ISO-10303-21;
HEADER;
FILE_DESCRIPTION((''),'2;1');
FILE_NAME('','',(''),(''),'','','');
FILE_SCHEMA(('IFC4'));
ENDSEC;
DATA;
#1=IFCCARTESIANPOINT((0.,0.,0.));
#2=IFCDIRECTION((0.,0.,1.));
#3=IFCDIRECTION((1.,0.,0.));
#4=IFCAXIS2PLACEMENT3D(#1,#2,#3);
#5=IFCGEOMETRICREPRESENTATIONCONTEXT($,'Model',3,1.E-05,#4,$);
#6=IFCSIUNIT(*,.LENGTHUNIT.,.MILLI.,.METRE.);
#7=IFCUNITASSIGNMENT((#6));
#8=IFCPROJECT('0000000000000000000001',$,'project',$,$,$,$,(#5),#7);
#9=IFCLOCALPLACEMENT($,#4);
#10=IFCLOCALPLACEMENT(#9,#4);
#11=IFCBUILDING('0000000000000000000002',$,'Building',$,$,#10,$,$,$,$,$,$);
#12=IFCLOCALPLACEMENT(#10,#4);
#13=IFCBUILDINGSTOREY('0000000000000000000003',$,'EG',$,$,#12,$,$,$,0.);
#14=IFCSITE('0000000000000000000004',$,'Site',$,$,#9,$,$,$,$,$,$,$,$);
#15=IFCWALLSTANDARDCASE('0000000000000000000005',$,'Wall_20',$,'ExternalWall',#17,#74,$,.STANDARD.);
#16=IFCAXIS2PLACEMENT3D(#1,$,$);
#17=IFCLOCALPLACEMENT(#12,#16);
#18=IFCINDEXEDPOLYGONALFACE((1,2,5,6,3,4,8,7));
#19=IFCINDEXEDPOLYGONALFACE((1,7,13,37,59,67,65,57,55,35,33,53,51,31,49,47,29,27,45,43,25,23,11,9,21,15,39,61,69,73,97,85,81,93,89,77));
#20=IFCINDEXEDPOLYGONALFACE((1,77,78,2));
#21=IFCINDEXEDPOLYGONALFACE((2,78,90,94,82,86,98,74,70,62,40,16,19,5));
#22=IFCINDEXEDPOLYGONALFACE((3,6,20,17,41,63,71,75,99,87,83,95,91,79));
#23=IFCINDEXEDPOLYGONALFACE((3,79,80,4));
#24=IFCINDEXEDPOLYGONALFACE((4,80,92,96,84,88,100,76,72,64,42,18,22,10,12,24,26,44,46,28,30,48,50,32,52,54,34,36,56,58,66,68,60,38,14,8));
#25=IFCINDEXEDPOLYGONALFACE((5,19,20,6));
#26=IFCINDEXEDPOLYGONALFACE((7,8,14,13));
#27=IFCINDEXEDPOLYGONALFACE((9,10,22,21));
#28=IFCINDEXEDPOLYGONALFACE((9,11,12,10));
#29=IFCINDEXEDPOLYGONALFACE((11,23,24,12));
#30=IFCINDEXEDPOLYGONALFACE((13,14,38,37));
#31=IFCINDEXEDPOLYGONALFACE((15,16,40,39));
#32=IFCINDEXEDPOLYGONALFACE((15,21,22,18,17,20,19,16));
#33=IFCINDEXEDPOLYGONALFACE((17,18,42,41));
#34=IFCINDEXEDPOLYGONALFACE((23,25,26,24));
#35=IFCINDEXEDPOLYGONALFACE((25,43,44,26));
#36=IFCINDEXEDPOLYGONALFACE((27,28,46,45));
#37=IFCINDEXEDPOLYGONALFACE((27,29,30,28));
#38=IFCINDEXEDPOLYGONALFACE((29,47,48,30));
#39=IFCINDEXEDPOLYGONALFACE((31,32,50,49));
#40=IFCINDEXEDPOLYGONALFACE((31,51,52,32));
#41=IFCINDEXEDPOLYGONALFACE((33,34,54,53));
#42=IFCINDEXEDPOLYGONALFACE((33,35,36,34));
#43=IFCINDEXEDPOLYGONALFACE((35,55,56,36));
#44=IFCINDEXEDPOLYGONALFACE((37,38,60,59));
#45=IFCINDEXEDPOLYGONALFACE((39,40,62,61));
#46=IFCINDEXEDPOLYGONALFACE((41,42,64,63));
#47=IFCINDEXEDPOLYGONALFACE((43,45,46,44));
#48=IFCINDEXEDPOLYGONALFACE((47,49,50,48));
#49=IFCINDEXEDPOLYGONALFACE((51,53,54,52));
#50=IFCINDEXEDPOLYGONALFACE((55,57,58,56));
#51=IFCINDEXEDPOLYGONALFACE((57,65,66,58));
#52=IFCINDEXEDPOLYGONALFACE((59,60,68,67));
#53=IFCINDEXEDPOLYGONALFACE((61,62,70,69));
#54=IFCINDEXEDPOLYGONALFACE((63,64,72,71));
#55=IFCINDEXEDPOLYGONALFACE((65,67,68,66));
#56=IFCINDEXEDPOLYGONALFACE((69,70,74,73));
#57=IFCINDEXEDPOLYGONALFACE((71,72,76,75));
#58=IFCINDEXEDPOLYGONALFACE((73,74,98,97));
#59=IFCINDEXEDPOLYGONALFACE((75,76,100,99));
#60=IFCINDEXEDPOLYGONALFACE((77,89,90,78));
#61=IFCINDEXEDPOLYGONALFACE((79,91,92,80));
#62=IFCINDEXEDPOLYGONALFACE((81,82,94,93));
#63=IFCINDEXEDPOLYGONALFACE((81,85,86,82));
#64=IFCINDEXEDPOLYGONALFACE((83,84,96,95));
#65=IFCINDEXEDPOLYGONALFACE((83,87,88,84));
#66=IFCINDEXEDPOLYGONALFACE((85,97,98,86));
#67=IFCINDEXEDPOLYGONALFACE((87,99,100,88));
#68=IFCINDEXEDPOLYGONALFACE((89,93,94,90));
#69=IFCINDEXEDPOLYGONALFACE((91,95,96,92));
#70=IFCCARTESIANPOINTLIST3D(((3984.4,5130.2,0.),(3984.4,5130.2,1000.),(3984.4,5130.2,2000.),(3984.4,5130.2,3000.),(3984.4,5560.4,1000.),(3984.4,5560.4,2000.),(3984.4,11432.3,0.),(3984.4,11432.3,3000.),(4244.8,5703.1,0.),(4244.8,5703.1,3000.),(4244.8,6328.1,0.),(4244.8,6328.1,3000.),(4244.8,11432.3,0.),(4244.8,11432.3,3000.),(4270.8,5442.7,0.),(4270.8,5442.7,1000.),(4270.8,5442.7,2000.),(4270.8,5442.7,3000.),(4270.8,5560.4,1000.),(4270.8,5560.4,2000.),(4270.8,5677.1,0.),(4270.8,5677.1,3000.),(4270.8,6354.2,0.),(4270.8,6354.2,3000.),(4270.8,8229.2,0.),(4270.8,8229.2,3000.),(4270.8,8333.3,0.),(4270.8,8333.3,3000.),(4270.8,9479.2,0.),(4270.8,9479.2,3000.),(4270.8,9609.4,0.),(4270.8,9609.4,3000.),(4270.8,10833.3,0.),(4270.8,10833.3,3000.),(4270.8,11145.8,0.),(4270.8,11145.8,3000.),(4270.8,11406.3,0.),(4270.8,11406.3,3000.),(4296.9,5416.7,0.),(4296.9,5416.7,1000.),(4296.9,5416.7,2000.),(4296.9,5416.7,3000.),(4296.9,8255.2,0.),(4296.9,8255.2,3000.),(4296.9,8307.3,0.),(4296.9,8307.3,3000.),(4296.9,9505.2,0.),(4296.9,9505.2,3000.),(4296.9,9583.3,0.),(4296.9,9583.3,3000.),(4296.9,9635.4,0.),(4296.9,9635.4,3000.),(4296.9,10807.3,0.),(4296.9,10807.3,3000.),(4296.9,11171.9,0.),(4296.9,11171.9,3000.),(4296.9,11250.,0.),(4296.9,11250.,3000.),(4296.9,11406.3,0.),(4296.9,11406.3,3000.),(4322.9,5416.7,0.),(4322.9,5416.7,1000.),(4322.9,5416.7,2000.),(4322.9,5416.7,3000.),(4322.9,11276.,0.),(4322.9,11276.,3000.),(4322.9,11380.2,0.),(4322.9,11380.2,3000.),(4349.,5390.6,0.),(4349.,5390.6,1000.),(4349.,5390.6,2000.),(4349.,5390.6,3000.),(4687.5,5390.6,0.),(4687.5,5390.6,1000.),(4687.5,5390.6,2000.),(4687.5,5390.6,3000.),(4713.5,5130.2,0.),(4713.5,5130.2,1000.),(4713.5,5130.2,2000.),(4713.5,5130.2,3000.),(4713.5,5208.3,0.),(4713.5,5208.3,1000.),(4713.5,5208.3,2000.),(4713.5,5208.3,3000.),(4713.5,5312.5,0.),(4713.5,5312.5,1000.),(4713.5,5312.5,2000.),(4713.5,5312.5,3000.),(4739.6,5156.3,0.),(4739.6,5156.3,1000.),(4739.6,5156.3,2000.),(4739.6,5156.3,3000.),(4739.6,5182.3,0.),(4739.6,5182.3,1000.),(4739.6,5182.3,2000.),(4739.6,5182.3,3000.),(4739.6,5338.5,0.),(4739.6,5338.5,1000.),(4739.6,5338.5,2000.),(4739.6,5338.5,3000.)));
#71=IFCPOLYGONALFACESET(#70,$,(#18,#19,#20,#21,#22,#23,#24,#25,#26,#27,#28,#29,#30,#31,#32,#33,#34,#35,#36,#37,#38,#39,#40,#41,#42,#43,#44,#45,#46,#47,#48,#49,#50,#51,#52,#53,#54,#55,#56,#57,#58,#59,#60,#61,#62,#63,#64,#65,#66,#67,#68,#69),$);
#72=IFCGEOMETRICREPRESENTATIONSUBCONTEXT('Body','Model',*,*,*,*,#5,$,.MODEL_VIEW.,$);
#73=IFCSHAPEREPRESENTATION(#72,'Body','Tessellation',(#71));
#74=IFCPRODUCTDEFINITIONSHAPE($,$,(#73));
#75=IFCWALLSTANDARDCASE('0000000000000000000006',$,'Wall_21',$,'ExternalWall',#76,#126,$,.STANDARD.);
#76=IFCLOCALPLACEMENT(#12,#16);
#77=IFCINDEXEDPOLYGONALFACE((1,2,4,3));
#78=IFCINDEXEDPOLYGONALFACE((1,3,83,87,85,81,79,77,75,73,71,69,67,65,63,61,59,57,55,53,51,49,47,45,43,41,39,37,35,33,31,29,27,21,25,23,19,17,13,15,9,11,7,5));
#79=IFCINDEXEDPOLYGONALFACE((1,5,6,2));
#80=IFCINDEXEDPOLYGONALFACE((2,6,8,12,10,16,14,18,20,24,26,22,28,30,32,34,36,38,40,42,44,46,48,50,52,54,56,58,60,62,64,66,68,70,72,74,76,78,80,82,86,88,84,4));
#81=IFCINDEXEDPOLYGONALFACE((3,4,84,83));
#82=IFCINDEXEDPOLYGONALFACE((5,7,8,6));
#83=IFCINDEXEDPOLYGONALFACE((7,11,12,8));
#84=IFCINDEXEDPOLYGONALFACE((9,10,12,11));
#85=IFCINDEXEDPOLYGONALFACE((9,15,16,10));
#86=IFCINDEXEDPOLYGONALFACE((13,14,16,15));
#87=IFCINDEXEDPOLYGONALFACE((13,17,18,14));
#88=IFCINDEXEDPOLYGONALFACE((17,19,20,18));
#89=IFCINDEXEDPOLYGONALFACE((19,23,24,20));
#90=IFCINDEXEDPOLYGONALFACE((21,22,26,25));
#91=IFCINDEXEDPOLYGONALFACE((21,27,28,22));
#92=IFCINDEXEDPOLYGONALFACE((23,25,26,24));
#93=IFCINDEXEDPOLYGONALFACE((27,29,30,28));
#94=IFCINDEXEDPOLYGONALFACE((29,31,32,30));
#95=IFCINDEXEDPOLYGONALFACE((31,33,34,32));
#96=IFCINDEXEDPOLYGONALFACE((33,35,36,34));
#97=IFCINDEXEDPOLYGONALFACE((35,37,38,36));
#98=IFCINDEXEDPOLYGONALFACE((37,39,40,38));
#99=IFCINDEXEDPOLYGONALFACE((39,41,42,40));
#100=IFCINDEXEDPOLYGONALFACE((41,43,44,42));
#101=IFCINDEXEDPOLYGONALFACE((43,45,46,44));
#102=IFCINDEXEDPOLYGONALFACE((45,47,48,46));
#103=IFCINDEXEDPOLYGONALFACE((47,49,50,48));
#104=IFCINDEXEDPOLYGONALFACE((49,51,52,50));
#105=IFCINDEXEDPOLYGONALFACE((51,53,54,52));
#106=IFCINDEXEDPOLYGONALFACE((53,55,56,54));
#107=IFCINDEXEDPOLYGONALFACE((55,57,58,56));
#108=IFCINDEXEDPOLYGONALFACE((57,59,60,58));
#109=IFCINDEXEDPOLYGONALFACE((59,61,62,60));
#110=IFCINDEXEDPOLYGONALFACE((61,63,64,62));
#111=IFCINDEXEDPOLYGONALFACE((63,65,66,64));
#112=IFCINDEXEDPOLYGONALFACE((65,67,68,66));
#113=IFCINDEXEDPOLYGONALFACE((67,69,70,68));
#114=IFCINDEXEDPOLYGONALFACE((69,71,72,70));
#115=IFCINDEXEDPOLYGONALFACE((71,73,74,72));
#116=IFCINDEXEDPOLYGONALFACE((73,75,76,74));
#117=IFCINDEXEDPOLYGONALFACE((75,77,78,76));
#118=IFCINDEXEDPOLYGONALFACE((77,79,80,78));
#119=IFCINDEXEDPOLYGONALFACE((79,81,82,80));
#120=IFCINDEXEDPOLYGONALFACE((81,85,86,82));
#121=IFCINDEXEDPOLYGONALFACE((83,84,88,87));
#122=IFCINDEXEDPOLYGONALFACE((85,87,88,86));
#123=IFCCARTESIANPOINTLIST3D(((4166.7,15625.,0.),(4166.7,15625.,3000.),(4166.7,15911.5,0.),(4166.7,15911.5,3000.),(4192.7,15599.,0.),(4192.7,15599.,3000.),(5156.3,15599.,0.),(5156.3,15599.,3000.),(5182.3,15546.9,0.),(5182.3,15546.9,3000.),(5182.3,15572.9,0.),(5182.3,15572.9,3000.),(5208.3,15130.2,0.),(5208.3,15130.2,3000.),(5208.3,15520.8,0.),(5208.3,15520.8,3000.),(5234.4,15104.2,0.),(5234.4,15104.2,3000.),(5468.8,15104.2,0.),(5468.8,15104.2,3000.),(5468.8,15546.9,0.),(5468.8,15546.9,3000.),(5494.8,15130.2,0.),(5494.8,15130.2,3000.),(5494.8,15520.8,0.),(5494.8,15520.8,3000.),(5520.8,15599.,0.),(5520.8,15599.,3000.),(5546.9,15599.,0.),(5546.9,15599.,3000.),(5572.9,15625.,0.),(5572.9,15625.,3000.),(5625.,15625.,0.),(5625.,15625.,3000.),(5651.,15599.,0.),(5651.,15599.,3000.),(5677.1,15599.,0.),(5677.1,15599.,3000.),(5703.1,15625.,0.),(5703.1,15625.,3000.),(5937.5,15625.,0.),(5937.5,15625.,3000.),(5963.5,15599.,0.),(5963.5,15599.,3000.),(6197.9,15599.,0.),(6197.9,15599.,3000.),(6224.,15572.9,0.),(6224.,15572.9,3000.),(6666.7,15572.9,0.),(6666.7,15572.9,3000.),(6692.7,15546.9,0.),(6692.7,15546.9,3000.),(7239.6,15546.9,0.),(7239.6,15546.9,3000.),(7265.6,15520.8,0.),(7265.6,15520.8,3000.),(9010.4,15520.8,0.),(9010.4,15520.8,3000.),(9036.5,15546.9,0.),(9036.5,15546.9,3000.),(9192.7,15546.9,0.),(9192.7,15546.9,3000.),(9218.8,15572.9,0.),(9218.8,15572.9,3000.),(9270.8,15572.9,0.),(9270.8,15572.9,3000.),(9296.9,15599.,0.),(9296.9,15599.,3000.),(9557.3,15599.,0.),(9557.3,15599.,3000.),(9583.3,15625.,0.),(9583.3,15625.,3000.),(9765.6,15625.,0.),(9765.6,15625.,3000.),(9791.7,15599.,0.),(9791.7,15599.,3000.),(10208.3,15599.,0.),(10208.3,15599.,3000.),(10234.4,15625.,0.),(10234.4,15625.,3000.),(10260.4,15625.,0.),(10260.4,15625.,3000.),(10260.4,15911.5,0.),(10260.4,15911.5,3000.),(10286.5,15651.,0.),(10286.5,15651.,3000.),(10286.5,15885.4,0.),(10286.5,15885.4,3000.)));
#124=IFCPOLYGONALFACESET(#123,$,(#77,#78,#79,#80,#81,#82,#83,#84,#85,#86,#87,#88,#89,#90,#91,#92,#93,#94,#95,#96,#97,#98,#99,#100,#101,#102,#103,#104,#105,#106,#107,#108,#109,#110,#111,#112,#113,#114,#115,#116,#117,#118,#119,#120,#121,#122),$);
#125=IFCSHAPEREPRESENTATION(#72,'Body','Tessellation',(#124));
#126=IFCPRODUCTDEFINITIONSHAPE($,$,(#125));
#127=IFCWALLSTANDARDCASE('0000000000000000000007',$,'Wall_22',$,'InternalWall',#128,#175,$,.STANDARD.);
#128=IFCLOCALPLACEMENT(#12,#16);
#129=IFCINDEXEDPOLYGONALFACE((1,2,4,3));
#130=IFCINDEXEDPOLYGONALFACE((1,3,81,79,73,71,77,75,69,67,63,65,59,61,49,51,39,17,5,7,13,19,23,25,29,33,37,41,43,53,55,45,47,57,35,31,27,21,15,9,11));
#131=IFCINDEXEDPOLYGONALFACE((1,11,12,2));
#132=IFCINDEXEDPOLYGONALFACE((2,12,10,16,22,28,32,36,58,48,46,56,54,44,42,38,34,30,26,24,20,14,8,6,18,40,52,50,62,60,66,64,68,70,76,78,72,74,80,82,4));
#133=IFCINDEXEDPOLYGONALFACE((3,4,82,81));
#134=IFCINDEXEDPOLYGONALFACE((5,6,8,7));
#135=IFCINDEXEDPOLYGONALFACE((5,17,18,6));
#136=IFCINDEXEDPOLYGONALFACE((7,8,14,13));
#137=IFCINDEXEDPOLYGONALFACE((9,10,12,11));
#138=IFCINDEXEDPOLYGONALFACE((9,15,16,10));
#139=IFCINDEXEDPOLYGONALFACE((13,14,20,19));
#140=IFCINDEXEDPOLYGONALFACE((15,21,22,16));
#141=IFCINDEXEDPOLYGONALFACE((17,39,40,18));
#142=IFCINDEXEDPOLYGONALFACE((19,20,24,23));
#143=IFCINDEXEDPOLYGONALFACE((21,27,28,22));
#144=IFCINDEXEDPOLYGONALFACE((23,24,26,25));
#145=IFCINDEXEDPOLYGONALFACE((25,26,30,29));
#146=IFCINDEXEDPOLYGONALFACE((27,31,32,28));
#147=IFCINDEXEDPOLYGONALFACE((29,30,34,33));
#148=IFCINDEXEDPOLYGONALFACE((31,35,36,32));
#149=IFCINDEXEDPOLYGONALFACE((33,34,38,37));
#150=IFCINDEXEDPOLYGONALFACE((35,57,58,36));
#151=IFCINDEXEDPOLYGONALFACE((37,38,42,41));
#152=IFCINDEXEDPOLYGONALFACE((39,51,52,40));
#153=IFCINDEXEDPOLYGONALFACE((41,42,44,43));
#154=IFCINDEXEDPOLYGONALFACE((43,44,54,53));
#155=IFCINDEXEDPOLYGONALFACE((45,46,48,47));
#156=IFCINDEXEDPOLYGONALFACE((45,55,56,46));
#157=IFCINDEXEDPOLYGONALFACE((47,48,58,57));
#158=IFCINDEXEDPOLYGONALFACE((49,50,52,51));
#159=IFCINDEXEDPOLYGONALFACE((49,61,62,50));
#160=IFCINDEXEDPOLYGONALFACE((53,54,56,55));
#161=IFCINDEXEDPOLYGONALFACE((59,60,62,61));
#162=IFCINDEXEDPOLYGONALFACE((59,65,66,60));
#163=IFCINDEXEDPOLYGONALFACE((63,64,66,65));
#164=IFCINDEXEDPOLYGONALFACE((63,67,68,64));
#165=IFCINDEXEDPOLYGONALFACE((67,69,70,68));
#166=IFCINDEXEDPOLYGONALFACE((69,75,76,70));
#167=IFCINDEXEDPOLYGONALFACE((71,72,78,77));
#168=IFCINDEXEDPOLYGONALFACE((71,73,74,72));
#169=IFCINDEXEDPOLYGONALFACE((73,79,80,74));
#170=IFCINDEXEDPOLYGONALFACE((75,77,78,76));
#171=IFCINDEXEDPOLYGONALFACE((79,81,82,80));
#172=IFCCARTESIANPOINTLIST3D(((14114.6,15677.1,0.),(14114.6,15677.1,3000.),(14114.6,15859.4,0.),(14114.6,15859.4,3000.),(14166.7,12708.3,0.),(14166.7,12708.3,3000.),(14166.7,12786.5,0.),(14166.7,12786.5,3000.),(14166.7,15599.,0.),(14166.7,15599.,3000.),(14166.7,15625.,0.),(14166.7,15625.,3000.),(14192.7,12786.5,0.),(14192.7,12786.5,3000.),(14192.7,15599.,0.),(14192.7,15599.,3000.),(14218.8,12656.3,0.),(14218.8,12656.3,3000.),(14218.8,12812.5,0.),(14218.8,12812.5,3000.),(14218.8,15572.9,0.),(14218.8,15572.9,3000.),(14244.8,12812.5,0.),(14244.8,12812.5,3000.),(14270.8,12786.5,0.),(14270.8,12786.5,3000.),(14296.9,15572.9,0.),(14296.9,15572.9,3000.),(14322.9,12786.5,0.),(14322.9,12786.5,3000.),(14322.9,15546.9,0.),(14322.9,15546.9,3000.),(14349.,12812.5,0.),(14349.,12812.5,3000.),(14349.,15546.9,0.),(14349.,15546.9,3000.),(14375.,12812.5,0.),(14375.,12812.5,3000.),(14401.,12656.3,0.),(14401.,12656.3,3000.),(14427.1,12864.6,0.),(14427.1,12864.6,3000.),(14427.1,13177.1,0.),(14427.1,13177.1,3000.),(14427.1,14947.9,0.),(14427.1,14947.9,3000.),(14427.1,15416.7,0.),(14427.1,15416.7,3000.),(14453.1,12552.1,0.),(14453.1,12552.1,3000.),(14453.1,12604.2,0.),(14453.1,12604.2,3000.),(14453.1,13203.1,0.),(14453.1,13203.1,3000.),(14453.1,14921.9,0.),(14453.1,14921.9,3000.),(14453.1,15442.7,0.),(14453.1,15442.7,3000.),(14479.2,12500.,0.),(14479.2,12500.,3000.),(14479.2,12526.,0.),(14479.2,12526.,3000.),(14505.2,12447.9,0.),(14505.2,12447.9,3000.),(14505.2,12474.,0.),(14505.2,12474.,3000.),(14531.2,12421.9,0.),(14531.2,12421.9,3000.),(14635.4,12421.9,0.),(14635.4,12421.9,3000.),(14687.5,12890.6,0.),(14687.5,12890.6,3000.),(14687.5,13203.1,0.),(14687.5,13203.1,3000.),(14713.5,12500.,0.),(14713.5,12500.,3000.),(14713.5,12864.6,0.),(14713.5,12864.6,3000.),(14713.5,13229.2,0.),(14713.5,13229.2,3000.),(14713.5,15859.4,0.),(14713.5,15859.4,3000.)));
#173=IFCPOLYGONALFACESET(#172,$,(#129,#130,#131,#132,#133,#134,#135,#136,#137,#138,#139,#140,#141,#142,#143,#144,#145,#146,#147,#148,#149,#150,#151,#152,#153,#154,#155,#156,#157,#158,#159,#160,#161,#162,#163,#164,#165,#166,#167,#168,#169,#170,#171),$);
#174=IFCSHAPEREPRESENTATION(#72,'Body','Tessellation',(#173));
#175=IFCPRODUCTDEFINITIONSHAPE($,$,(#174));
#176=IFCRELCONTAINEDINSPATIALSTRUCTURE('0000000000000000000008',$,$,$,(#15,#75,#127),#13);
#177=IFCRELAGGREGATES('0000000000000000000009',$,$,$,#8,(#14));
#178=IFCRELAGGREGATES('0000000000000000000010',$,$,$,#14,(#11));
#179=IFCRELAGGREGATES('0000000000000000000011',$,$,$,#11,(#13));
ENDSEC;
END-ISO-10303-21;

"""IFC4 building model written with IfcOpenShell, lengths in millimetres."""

from ifc_helpers import new_model, si_unit, frame, origin_with_axes, place, context, subcontext, project, spatial, polyline, rectangle, outline, extrude, element, save


model = new_model("IFC4")

# Units and contexts
model_context = context("Model", 3, precision=1e-05, world=origin_with_axes())
body_context = subcontext(model_context, "Body", "Model", "MODEL_VIEW")
ifc_project = project(units=[si_unit("LENGTHUNIT", "METRE", prefix="MILLI")], contexts=[model_context])

# Site, building, storey
site_placement = place(None, origin_with_axes())
site = spatial("IfcSite", under=ifc_project, at=site_placement, Name="Site")
building_placement = place(site_placement, origin_with_axes())
building = spatial("IfcBuilding", under=site, at=building_placement, Name="Building")
storey_placement = place(building_placement, origin_with_axes())
storey = spatial("IfcBuildingStorey", under=building, at=storey_placement, Name="EG", Elevation=0.0)

# Wall, opening
wall_1_placement = place(storey_placement, origin_with_axes())
wall_1 = element("IfcWallStandardCase", 1, at=wall_1_placement, inside=storey, Name="Wall_20", ObjectType="ExternalWall", PredefinedType="STANDARD", context=body_context, shape_type="SweptSolid", body=[
    extrude(outline(polyline([(3984.4, 5130.2, 0.0), (3984.4, 11432.3, 0.0), (4244.8, 11432.3, 0.0), (4270.8, 11406.3, 0.0), (4296.9, 11406.3, 0.0), (4322.9, 11380.2, 0.0), (4322.9, 11276.0, 0.0), (4296.9, 11250.0, 0.0), (4296.9, 11171.9, 0.0), (4270.8, 11145.8, 0.0), (4270.8, 10833.3, 0.0), (4296.9, 10807.3, 0.0), (4296.9, 9635.4, 0.0), (4270.8, 9609.4, 0.0), (4296.9, 9583.3, 0.0), (4296.9, 9505.2, 0.0), (4270.8, 9479.2, 0.0), (4270.8, 8333.3, 0.0), (4296.9, 8307.3, 0.0), (4296.9, 8255.2, 0.0), (4270.8, 8229.2, 0.0), (4270.8, 6354.2, 0.0), (4244.8, 6328.1, 0.0), (4244.8, 5703.1, 0.0), (4270.8, 5677.1, 0.0), (4270.8, 5442.7, 0.0), (4296.9, 5416.7, 0.0), (4322.9, 5416.7, 0.0), (4349.0, 5390.6, 0.0), (4687.5, 5390.6, 0.0), (4739.6, 5338.5, 0.0), (4713.5, 5312.5, 0.0), (4713.5, 5208.3, 0.0), (4739.6, 5182.3, 0.0), (4739.6, 5156.3, 0.0), (4713.5, 5130.2, 0.0), (3984.4, 5130.2, 0.0)])), origin_with_axes(), (0.0, 0.0, 1.0), 3000.0),
])
opening_1_placement = place(wall_1_placement, origin_with_axes())
element("IfcOpeningElement", 2, at=opening_1_placement, inside=storey, cuts=wall_1, context=body_context, shape_type="SweptSolid", body=[
    extrude(rectangle(XDim=600.0, YDim=755.2), frame((4362.0, 5260.4, 1000.0), z_axis=(0.0, 0.0, 1.0), x_axis=(0.0, 1.0, 0.0)), (0.0, 0.0, 1.0), 1000.0),
])

# Walls
wall_2_placement = place(storey_placement, origin_with_axes())
element("IfcWallStandardCase", 3, at=wall_2_placement, inside=storey, Name="Wall_21", ObjectType="ExternalWall", PredefinedType="STANDARD", context=body_context, shape_type="SweptSolid", body=[
    extrude(outline(polyline([(5234.4, 15104.2, 0.0), (5208.3, 15130.2, 0.0), (5208.3, 15520.8, 0.0), (5182.3, 15546.9, 0.0), (5182.3, 15572.9, 0.0), (5156.3, 15599.0, 0.0), (4192.7, 15599.0, 0.0), (4166.7, 15625.0, 0.0), (4166.7, 15911.5, 0.0), (10260.4, 15911.5, 0.0), (10286.5, 15885.4, 0.0), (10286.5, 15651.0, 0.0), (10260.4, 15625.0, 0.0), (10234.4, 15625.0, 0.0), (10208.3, 15599.0, 0.0), (9791.7, 15599.0, 0.0), (9765.6, 15625.0, 0.0), (9583.3, 15625.0, 0.0), (9557.3, 15599.0, 0.0), (9296.9, 15599.0, 0.0), (9270.8, 15572.9, 0.0), (9218.8, 15572.9, 0.0), (9192.7, 15546.9, 0.0), (9036.5, 15546.9, 0.0), (9010.4, 15520.8, 0.0), (7265.6, 15520.8, 0.0), (7239.6, 15546.9, 0.0), (6692.7, 15546.9, 0.0), (6666.7, 15572.9, 0.0), (6224.0, 15572.9, 0.0), (6197.9, 15599.0, 0.0), (5963.5, 15599.0, 0.0), (5937.5, 15625.0, 0.0), (5703.1, 15625.0, 0.0), (5677.1, 15599.0, 0.0), (5651.0, 15599.0, 0.0), (5625.0, 15625.0, 0.0), (5572.9, 15625.0, 0.0), (5546.9, 15599.0, 0.0), (5520.8, 15599.0, 0.0), (5468.8, 15546.9, 0.0), (5494.8, 15520.8, 0.0), (5494.8, 15130.2, 0.0), (5468.8, 15104.2, 0.0), (5234.4, 15104.2, 0.0)])), origin_with_axes(), (0.0, 0.0, 1.0), 3000.0),
])
wall_3_placement = place(storey_placement, origin_with_axes())
element("IfcWallStandardCase", 4, at=wall_3_placement, inside=storey, Name="Wall_22", ObjectType="InternalWall", PredefinedType="STANDARD", context=body_context, shape_type="SweptSolid", body=[
    extrude(outline(polyline([(14531.2, 12421.9, 0.0), (14505.2, 12447.9, 0.0), (14505.2, 12474.0, 0.0), (14479.2, 12500.0, 0.0), (14479.2, 12526.0, 0.0), (14453.1, 12552.1, 0.0), (14453.1, 12604.2, 0.0), (14401.0, 12656.3, 0.0), (14218.8, 12656.3, 0.0), (14166.7, 12708.3, 0.0), (14166.7, 12786.5, 0.0), (14192.7, 12786.5, 0.0), (14218.8, 12812.5, 0.0), (14244.8, 12812.5, 0.0), (14270.8, 12786.5, 0.0), (14322.9, 12786.5, 0.0), (14349.0, 12812.5, 0.0), (14375.0, 12812.5, 0.0), (14427.1, 12864.6, 0.0), (14427.1, 13177.1, 0.0), (14453.1, 13203.1, 0.0), (14453.1, 14921.9, 0.0), (14427.1, 14947.9, 0.0), (14427.1, 15416.7, 0.0), (14453.1, 15442.7, 0.0), (14349.0, 15546.9, 0.0), (14322.9, 15546.9, 0.0), (14296.9, 15572.9, 0.0), (14218.8, 15572.9, 0.0), (14192.7, 15599.0, 0.0), (14166.7, 15599.0, 0.0), (14166.7, 15625.0, 0.0), (14114.6, 15677.1, 0.0), (14114.6, 15859.4, 0.0), (14713.5, 15859.4, 0.0), (14713.5, 13229.2, 0.0), (14687.5, 13203.1, 0.0), (14687.5, 12890.6, 0.0), (14713.5, 12864.6, 0.0), (14713.5, 12500.0, 0.0), (14635.4, 12421.9, 0.0), (14531.2, 12421.9, 0.0)])), origin_with_axes(), (0.0, 0.0, 1.0), 3000.0),
])

save(model, "model.ifc")
